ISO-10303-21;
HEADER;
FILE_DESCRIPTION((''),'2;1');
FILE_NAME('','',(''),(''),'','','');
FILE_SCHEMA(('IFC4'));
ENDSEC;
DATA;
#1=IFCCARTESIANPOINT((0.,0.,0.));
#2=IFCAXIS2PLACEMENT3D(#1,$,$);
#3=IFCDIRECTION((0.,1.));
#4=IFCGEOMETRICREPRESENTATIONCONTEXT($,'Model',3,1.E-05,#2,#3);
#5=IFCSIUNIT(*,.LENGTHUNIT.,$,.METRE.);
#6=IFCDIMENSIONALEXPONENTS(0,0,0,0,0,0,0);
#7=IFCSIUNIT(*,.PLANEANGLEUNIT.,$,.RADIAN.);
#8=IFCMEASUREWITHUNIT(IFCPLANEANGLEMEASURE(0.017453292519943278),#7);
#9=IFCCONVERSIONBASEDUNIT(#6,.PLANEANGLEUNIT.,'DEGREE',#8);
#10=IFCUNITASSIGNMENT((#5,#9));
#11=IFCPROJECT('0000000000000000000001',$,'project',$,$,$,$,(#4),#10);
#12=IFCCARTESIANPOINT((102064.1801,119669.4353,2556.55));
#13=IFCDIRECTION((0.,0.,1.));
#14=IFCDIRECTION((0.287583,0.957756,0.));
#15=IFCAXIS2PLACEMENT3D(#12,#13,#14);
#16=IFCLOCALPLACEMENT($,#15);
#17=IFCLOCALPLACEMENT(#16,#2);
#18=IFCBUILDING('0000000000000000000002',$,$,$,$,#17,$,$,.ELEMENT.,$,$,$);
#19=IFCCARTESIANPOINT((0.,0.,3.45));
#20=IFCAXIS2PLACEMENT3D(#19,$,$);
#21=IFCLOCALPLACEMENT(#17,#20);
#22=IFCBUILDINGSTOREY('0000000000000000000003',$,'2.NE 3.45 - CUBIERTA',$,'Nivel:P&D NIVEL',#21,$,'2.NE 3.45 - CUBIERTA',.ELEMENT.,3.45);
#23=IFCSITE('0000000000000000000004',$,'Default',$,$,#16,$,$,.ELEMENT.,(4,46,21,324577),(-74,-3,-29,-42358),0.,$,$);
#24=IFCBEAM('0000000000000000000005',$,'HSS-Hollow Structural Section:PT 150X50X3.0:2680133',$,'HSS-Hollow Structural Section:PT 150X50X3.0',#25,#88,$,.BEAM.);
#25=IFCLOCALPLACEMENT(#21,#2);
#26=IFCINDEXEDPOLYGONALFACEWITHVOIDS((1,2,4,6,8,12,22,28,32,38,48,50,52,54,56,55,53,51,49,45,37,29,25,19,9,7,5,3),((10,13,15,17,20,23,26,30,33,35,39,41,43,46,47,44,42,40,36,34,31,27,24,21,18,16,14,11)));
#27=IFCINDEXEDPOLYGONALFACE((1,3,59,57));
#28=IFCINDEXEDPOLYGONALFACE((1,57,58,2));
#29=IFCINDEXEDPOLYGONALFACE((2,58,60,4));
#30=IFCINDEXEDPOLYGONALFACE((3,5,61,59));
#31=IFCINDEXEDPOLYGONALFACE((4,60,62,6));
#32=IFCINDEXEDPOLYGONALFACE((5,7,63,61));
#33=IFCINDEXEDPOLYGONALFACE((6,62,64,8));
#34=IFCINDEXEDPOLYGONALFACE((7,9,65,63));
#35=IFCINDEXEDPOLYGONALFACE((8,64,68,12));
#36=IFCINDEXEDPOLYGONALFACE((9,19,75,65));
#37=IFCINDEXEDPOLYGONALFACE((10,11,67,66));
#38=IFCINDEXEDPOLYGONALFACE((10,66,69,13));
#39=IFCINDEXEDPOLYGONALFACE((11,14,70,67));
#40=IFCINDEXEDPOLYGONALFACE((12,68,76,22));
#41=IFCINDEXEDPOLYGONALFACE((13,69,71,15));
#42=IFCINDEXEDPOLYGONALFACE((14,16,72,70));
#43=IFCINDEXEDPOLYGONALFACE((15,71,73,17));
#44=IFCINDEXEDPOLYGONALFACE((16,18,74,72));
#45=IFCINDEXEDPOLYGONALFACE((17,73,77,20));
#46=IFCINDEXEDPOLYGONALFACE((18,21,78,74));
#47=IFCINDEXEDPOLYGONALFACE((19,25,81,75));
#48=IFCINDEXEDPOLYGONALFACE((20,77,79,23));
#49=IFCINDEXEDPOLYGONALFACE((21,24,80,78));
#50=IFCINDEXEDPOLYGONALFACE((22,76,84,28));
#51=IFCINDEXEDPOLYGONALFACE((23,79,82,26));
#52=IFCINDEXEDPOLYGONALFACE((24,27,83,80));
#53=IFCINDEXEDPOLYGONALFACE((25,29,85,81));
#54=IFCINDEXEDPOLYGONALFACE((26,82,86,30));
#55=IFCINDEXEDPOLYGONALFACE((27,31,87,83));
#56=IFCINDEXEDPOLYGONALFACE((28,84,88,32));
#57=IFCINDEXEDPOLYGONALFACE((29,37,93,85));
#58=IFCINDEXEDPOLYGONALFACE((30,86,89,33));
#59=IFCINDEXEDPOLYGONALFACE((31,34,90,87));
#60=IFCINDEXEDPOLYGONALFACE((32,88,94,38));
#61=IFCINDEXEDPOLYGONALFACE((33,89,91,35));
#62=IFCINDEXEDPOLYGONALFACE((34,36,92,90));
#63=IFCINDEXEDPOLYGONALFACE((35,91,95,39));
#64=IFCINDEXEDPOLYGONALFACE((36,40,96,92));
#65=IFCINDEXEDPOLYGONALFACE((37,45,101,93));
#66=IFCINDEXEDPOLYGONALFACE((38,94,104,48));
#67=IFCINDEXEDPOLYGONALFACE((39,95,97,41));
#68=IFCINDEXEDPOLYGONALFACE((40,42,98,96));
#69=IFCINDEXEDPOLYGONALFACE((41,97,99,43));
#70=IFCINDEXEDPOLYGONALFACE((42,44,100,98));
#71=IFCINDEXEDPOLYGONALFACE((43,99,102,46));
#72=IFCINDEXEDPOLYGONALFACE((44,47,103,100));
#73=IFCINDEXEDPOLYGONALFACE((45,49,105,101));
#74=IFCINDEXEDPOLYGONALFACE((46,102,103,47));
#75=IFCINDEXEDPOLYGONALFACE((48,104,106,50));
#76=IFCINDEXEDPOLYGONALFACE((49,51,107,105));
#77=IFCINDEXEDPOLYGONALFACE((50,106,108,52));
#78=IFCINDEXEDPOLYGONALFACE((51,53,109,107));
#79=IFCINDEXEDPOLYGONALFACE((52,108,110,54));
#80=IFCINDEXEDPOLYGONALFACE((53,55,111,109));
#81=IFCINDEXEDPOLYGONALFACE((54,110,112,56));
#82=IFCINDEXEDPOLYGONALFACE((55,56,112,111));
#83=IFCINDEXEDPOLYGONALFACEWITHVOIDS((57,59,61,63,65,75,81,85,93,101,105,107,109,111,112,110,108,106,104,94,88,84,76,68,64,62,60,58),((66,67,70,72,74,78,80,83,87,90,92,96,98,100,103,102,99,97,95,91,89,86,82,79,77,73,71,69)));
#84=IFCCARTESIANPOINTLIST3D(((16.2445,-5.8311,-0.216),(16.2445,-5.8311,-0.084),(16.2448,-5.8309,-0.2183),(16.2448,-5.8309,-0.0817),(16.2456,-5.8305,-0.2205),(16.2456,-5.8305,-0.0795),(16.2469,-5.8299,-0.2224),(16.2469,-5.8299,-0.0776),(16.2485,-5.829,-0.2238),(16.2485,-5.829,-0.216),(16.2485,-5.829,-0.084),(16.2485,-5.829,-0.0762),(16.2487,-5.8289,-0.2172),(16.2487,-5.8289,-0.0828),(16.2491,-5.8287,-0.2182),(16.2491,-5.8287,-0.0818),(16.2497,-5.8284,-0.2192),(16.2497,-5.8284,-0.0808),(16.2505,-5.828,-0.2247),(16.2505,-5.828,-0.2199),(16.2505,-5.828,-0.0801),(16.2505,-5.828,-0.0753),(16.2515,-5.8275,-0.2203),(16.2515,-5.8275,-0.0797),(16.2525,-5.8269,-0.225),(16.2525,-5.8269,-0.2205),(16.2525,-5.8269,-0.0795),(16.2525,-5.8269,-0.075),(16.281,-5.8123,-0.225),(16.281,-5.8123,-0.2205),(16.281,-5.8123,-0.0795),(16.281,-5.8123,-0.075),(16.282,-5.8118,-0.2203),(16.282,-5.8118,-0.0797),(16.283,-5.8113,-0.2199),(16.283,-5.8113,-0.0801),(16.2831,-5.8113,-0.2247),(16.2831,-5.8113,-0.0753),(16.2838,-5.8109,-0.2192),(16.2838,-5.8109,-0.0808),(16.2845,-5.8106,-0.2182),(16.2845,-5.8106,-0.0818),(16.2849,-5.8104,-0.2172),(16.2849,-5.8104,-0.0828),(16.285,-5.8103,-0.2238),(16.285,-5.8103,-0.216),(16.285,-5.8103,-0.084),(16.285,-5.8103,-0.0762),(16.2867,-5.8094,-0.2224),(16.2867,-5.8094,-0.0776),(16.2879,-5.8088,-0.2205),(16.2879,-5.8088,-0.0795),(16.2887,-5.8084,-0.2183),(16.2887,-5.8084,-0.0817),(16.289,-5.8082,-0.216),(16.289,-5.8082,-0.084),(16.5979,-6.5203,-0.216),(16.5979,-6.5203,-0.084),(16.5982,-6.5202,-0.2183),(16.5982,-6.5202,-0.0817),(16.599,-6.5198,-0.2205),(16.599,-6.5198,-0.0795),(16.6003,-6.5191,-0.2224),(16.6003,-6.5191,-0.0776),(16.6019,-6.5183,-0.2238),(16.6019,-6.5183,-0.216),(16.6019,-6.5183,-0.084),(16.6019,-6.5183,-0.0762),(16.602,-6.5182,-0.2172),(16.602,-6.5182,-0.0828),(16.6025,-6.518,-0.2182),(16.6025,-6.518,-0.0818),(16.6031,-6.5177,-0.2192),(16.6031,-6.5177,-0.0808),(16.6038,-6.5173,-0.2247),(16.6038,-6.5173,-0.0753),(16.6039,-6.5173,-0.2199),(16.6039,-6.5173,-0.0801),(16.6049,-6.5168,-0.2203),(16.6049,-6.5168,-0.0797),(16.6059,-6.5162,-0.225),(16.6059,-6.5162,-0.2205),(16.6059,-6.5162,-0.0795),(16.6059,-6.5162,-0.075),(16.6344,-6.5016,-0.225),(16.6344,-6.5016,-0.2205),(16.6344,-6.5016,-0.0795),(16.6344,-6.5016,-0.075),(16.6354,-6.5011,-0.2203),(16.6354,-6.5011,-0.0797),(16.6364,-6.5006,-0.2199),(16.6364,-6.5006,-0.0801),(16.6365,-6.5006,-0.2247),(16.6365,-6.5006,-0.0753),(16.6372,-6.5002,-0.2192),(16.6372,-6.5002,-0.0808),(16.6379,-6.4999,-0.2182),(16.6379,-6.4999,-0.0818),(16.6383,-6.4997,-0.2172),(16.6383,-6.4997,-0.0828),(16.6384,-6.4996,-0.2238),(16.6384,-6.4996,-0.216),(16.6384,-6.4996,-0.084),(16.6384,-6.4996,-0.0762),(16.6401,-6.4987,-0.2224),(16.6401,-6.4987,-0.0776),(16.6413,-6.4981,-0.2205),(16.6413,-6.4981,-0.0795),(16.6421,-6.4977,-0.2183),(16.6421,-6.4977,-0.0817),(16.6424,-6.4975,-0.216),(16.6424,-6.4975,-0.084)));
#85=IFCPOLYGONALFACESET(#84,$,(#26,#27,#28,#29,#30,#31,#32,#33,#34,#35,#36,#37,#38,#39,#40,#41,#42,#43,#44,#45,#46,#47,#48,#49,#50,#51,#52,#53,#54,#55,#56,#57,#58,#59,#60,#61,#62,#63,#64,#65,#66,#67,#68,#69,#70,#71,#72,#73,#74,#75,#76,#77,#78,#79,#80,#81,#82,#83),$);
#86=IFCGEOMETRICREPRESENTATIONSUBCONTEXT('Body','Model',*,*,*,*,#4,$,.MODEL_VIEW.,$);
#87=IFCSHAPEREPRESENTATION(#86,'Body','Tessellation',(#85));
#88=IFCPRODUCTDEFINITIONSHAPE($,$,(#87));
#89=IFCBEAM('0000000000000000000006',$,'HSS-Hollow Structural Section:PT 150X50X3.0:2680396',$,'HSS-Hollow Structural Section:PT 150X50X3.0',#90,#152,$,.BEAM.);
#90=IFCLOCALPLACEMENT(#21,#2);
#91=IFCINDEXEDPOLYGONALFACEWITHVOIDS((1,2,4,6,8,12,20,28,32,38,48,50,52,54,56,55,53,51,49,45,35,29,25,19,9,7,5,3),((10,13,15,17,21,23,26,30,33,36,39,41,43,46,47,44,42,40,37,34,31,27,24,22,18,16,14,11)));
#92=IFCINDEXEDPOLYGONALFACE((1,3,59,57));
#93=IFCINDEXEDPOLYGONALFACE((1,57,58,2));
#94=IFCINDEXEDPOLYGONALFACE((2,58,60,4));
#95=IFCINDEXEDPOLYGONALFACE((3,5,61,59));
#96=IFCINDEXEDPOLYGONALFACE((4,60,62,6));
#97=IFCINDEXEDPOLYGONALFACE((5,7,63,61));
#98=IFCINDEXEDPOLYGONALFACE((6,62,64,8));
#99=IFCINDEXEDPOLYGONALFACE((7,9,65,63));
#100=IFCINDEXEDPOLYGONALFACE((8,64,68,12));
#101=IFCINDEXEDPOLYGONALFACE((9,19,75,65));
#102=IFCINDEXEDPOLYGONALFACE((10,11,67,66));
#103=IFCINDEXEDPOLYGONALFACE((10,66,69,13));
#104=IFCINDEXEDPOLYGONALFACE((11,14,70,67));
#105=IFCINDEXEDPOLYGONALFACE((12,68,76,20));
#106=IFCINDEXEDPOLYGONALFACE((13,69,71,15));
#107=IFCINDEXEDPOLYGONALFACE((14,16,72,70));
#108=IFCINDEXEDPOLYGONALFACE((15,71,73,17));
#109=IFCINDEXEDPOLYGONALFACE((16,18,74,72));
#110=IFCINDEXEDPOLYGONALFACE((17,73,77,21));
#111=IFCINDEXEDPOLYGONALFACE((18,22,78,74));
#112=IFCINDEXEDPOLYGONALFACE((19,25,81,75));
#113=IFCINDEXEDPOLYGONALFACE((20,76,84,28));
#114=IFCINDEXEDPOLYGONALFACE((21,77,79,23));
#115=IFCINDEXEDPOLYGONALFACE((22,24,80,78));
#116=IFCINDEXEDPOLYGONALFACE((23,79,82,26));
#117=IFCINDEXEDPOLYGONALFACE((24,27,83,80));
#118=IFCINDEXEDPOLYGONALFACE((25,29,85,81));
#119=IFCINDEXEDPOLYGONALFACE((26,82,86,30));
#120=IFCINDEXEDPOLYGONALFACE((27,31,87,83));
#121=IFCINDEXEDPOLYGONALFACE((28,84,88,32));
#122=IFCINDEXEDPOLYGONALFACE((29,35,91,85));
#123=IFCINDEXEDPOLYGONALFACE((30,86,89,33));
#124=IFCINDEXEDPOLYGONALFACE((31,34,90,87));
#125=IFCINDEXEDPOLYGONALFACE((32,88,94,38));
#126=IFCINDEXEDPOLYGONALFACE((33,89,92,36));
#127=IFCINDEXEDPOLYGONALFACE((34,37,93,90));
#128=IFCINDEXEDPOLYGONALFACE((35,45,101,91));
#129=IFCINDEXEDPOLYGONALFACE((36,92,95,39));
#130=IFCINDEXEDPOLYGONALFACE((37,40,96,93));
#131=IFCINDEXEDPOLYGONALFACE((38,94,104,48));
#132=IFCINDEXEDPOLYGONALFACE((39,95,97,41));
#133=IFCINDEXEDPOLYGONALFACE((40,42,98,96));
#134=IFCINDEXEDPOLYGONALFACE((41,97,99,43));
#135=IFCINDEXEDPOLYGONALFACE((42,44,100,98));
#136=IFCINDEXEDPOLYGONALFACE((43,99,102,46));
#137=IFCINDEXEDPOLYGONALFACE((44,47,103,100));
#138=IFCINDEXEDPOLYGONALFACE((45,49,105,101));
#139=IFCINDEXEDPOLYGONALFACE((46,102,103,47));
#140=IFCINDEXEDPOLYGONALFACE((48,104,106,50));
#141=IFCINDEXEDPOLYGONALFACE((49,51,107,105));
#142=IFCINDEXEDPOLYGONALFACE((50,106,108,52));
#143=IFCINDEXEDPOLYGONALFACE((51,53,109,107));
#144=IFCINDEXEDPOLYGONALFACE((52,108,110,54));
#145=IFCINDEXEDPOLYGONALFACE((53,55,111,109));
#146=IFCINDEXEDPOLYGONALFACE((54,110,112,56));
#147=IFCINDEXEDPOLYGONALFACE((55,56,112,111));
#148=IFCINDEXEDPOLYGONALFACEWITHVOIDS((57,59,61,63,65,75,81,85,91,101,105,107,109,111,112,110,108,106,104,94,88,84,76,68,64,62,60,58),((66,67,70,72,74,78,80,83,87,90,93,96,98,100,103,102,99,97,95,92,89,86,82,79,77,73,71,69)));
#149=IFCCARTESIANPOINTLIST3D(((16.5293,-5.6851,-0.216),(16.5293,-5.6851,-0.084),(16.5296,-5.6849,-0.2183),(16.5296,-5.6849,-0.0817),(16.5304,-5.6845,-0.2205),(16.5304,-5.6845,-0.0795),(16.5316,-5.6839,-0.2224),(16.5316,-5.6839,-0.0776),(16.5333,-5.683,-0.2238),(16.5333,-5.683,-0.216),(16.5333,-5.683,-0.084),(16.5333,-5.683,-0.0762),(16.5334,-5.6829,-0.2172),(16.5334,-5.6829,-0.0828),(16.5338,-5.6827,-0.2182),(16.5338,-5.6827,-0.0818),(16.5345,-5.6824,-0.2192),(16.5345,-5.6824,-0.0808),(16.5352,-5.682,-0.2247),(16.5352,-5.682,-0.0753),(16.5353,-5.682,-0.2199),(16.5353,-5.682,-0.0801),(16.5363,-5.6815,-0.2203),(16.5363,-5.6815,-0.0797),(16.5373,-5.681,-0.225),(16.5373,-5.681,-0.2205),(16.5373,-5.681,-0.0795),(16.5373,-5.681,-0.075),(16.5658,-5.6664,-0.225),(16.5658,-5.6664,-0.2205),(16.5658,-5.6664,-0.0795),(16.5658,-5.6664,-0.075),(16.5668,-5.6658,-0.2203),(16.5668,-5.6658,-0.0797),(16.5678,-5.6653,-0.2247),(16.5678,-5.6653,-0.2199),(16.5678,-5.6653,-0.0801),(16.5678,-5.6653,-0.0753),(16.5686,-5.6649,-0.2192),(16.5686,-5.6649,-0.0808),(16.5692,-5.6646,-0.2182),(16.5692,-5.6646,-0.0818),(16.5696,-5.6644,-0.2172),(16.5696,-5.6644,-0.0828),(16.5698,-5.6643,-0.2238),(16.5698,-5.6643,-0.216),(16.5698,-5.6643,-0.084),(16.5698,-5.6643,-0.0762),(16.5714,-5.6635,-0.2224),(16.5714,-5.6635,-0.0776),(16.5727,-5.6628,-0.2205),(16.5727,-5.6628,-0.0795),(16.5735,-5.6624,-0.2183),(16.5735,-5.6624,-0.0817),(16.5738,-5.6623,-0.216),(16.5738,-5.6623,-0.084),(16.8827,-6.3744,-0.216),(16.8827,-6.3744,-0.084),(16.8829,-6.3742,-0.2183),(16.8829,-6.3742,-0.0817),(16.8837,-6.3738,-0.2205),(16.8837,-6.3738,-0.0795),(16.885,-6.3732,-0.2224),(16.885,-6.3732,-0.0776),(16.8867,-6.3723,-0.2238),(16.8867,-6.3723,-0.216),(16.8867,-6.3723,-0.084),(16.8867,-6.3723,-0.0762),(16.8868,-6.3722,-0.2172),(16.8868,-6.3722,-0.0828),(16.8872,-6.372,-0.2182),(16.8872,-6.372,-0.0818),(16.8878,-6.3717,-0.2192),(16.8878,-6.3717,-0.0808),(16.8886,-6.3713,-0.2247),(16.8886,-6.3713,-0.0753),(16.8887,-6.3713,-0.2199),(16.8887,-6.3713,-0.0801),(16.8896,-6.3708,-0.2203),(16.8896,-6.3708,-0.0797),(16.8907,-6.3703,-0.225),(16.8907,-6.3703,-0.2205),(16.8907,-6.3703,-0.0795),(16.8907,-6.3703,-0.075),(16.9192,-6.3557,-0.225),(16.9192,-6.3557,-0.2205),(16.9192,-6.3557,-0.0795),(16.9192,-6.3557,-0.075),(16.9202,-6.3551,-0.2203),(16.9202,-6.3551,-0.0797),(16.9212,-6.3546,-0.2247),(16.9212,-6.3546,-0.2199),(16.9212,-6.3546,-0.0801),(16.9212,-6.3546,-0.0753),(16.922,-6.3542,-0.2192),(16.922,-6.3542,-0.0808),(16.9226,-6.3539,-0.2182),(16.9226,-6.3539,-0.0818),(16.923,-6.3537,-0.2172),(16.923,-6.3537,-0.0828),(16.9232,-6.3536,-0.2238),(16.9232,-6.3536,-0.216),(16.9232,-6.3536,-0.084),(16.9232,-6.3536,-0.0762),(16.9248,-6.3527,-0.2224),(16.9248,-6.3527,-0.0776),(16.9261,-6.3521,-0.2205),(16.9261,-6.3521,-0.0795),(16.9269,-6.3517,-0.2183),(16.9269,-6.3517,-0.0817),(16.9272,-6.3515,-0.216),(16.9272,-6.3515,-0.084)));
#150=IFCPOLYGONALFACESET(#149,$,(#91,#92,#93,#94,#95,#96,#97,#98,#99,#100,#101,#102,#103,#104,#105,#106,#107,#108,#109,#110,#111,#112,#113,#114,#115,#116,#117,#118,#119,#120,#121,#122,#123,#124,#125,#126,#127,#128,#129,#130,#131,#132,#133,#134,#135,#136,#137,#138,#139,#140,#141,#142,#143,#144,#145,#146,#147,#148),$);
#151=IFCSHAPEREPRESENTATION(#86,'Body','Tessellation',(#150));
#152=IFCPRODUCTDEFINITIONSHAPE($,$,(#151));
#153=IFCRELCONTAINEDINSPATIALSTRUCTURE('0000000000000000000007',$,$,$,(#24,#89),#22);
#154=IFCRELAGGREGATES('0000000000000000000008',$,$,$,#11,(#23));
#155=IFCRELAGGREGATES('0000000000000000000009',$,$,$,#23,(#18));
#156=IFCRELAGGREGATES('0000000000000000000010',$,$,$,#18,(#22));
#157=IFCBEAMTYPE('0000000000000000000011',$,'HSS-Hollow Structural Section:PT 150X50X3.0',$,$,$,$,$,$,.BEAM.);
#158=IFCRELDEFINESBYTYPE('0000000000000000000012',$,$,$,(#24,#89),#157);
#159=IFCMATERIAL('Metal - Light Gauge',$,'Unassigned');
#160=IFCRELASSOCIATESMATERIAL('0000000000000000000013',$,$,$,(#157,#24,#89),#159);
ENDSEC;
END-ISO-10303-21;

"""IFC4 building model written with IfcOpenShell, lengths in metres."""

from ifc_helpers import new_model, entity, si_unit, converted_unit, direction, frame, origin, place, context, subcontext, project, spatial, line, arc, indexed_curve, outline, extrude, source, transform, mapped, material, type_object, type_shapes, element, save


model = new_model("IFC4")

# Units and contexts
model_context = context("Model", 3, precision=1e-05, world=origin(), true_north=direction((0.0, 1.0)))
body_context = subcontext(model_context, "Body", "Model", "MODEL_VIEW")
ifc_project = project(units=[si_unit("LENGTHUNIT", "METRE"), converted_unit("PLANEANGLEUNIT", "DEGREE", entity("IfcPlaneAngleMeasure", 0.017453292519943278), si_unit("PLANEANGLEUNIT", "RADIAN"), dimensions=[0, 0, 0, 0, 0, 0, 0])], contexts=[model_context])

# Site, building, storey
site_placement = place(None, frame((102064.1801, 119669.4353, 2556.55), z_axis=(0.0, 0.0, 1.0), x_axis=(0.287583, 0.957756, 0.0)))
site = spatial("IfcSite", under=ifc_project, at=site_placement, Name="Default", CompositionType="ELEMENT", RefLatitude=(4, 46, 21, 324577), RefLongitude=(-74, -3, -29, -42358), RefElevation=0.0)
building_placement = place(site_placement, origin())
building = spatial("IfcBuilding", under=site, at=building_placement, CompositionType="ELEMENT")
storey_placement = place(building_placement, frame((0.0, 0.0, 3.45)))
storey = spatial("IfcBuildingStorey", under=building, at=storey_placement, Name="2.NE 3.45 - CUBIERTA", ObjectType="Nivel:P&D NIVEL", LongName="2.NE 3.45 - CUBIERTA", CompositionType="ELEMENT", Elevation=3.45)

# Beams
ifc_material_1 = material(Name="Metal - Light Gauge", Category="Unassigned")
beam_type_1 = type_object("IfcBeamType", Name="HSS-Hollow Structural Section:PT 150X50X3.0", PredefinedType="BEAM", material=ifc_material_1)
shared_shape_1 = source(origin(), body_context, "Body", "SweptSolid", [
    extrude(outline(indexed_curve([(-0.025, -0.066), (-0.0224, -0.0724), (-0.016, -0.075), (0.016, -0.075), (0.0224, -0.0724), (0.025, -0.066), (0.025, 0.066), (0.0224, 0.0724), (0.016, 0.075), (-0.016, 0.075), (-0.0224, 0.0724), (-0.025, 0.066)], segments=[arc(1, 2, 3), line(3, 4), arc(4, 5, 6), line(6, 7), arc(7, 8, 9), line(9, 10), arc(10, 11, 12), line(12, 1)], self_intersect=False), holes=[indexed_curve([(0.016, -0.0705), (-0.016, -0.0705), (-0.0192, -0.0692), (-0.0205, -0.066), (-0.0205, 0.066), (-0.0192, 0.0692), (-0.016, 0.0705), (0.016, 0.0705), (0.0192, 0.0692), (0.0205, 0.066), (0.0205, -0.066), (0.0192, -0.0692)], segments=[line(1, 2), arc(2, 3, 4), line(4, 5), arc(5, 6, 7), line(7, 8), arc(8, 9, 10), line(10, 11), arc(11, 12, 1)], self_intersect=False)]), frame((-0.3873, 0.0, 0.0), z_axis=(1.0, 0.0, 0.0), x_axis=(0.0, -1.0, 0.0)), (0.0, 0.0, 1.0), 0.7746),
])
type_shapes(beam_type_1, [shared_shape_1])
for number, where, z_axis, x_axis, name in (
    (1, (16.4435, -6.1643, -0.15), (0.0, 0.0, 1.0), (-0.456217, 0.889869, 0.0), "HSS-Hollow Structural Section:PT 150X50X3.0:2680133"),
    (2, (16.7282, -6.0183, -0.15), (0.0, 0.0, 1.0), (-0.456217, 0.889869, 0.0), "HSS-Hollow Structural Section:PT 150X50X3.0:2680396"),
):
    element("IfcBeam", number, at=place(storey_placement, frame(where, z_axis=z_axis, x_axis=x_axis)), inside=storey, type_object=beam_type_1, material=ifc_material_1, Name=name, ObjectType="HSS-Hollow Structural Section:PT 150X50X3.0", PredefinedType="BEAM", context=body_context, shape_type="MappedRepresentation", body=[
        mapped(shared_shape_1, transform((0.0, 0.0, 0.0), scale=1.0)),
    ])

save(model, "model.ifc")
